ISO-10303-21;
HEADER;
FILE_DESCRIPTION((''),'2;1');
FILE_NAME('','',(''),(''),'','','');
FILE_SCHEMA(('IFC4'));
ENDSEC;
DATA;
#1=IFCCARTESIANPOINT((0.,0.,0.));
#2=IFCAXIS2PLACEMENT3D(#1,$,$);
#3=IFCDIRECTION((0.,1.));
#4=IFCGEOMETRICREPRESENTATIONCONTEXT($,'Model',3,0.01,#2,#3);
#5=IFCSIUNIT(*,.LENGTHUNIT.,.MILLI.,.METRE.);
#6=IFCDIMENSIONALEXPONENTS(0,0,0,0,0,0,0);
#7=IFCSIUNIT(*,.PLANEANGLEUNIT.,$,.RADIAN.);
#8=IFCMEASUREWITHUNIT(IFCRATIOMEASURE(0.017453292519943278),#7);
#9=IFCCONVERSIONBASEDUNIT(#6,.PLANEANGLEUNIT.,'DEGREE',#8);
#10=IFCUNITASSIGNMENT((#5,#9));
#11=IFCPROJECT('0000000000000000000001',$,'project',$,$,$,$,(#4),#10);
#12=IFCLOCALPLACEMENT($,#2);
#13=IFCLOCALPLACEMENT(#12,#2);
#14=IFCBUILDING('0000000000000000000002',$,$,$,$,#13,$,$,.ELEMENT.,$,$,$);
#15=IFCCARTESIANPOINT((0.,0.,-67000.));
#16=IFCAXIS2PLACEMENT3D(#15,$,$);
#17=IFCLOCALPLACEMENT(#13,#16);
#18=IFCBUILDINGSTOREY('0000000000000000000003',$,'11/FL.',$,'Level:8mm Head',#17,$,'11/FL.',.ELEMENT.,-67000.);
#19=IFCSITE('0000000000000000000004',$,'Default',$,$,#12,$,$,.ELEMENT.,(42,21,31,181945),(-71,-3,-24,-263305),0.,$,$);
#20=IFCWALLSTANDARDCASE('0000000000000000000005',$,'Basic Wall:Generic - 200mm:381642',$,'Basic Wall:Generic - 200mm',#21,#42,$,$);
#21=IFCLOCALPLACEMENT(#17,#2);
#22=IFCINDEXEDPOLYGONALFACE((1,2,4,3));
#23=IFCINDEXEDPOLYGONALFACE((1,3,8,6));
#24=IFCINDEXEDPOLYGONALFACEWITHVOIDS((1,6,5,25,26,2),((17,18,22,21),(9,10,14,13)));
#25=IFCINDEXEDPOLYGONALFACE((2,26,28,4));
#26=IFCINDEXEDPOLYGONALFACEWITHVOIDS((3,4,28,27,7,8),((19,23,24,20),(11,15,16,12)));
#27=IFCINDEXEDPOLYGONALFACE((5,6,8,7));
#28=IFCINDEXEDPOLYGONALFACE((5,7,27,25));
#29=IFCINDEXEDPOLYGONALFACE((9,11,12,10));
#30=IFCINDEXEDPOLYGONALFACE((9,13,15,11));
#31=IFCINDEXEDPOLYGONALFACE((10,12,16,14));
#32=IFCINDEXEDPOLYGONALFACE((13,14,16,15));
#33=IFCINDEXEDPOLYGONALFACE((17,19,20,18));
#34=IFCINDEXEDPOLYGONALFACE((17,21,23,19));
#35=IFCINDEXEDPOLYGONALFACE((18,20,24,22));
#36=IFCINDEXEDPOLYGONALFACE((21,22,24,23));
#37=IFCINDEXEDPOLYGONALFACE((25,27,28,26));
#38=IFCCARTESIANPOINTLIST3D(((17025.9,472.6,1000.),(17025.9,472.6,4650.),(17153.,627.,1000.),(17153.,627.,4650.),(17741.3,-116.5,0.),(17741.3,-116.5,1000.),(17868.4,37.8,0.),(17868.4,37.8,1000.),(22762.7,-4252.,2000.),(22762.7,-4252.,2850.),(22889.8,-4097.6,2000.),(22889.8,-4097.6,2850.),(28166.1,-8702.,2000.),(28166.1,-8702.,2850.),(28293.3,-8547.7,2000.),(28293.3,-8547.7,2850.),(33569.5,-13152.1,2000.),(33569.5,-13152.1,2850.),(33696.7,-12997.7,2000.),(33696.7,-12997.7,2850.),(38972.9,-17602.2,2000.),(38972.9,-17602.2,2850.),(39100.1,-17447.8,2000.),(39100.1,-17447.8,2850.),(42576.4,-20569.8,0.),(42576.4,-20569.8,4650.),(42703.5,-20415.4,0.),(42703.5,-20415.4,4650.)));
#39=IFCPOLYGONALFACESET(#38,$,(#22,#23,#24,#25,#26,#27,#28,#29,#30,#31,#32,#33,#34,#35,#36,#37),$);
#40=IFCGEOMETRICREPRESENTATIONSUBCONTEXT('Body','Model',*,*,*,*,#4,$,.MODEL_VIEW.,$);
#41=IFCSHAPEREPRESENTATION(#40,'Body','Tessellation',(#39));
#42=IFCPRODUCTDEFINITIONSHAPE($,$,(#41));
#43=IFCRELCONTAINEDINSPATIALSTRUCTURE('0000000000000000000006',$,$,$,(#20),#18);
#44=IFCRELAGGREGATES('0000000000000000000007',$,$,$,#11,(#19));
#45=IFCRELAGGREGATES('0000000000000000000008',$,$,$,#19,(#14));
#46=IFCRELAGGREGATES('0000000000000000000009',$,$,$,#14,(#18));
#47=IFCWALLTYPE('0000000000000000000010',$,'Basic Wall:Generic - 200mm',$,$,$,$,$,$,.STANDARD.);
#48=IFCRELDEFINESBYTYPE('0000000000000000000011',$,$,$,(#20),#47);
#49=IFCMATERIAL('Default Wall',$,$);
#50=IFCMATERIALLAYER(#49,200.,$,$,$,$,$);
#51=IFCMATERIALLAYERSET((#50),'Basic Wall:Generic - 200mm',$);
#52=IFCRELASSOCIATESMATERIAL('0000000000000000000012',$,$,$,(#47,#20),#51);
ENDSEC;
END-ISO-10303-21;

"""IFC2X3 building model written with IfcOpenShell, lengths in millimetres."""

from ifc_helpers import new_model, entity, si_unit, converted_unit, direction, frame, frame_2d, origin, origin_2d_with_axis, place, context, subcontext, project, spatial, rectangle, extrude, material, layer, layer_set, layer_usage, type_object, element, save


model = new_model("IFC2X3")

# Units and contexts
model_context = context("Model", 3, precision=0.01, world=origin(), true_north=direction((0.0, 1.0)))
body_context = subcontext(model_context, "Body", "Model", "MODEL_VIEW")
ifc_project = project(units=[si_unit("LENGTHUNIT", "METRE", prefix="MILLI"), converted_unit("PLANEANGLEUNIT", "DEGREE", entity("IfcRatioMeasure", 0.017453292519943278), si_unit("PLANEANGLEUNIT", "RADIAN"), dimensions=[0, 0, 0, 0, 0, 0, 0])], contexts=[model_context])

# Site, building, storey
site_placement = place(None, origin())
site = spatial("IfcSite", under=ifc_project, at=site_placement, Name="Default", CompositionType="ELEMENT", RefLatitude=(42, 21, 31, 181945), RefLongitude=(-71, -3, -24, -263305), RefElevation=0.0)
building_placement = place(site_placement, origin())
building = spatial("IfcBuilding", under=site, at=building_placement, CompositionType="ELEMENT")
storey_placement = place(building_placement, frame((0.0, 0.0, -67000.0)))
storey = spatial("IfcBuildingStorey", under=building, at=storey_placement, Name="11/FL.", ObjectType="Level:8mm Head", LongName="11/FL.", CompositionType="ELEMENT", Elevation=-67000.0)

# Wall, openings
ifc_material_1 = material(Name="Default Wall")
ifc_layer = layer(ifc_material_1, 200.0)
ifc_layer_set = layer_set([ifc_layer], Name="Basic Wall:Generic - 200mm")
ifc_layer_usage = layer_usage(ifc_layer_set, "AXIS2", "NEGATIVE", 100.0)
wall_type = type_object("IfcWallType", Name="Basic Wall:Generic - 200mm", PredefinedType="STANDARD", material=ifc_layer_set)
wall_1_placement = place(storey_placement, frame((42639.9, -20492.6, 0.0), z_axis=(0.0, 0.0, 1.0), x_axis=(-0.771917, 0.635723, 0.0)))
wall_1 = element("IfcWallStandardCase", 1, at=wall_1_placement, inside=storey, type_object=wall_type, material=ifc_layer_usage, Name="Basic Wall:Generic - 200mm:381642", ObjectType="Basic Wall:Generic - 200mm", context=body_context, shape_type="SweptSolid", body=[
    extrude(rectangle(XDim=33100.0, YDim=200.0, at=frame_2d((16550.0, 0.0), x_axis=(-1.0, 0.0))), origin(), (0.0, 0.0, 1.0), 4650.0),
])
opening_1_placement = place(wall_1_placement, origin())
element("IfcOpeningElement", 2, at=opening_1_placement, cuts=wall_1, ObjectType="Opening", context=body_context, shape_type="SweptSolid", body=[
    extrude(rectangle(XDim=850.0, YDim=7000.0, at=frame_2d((0.0, 0.0), x_axis=(1.0, 0.0))), frame((8168.1, -100.0, 2425.0), z_axis=(0.0, 1.0, 0.0), x_axis=(0.0, 0.0, -1.0)), (0.0, 0.0, 1.0), 200.0),
])
opening_2_placement = place(wall_1_placement, origin())
element("IfcOpeningElement", 3, at=opening_2_placement, cuts=wall_1, ObjectType="Opening", context=body_context, shape_type="SweptSolid", body=[
    extrude(rectangle(XDim=850.0, YDim=7000.0, at=origin_2d_with_axis()), frame((22168.1, -100.0, 2425.0), z_axis=(0.0, 1.0, 0.0), x_axis=(0.0, 0.0, -1.0)), (0.0, 0.0, 1.0), 200.0),
])
opening_3_placement = place(wall_1_placement, frame((45942.1, 11288.6, 0.0), z_axis=(0.0, 0.0, 1.0), x_axis=(-0.771917, -0.635723, 0.0)))
element("IfcOpeningElement", 4, at=opening_3_placement, cuts=wall_1, ObjectType="Opening", context=body_context, shape_type="SweptSolid", body=[
    extrude(rectangle(XDim=1000.0, YDim=1010.1, at=frame_2d((0.0, 0.0), x_axis=(1.0, 0.0))), frame((17486.6, 368.7, 500.0), z_axis=(-0.635723, -0.771917, 0.0), x_axis=(0.0, 0.0, -1.0)), (0.0, 0.0, 1.0), 1012.7),
])

save(model, "model.ifc")
